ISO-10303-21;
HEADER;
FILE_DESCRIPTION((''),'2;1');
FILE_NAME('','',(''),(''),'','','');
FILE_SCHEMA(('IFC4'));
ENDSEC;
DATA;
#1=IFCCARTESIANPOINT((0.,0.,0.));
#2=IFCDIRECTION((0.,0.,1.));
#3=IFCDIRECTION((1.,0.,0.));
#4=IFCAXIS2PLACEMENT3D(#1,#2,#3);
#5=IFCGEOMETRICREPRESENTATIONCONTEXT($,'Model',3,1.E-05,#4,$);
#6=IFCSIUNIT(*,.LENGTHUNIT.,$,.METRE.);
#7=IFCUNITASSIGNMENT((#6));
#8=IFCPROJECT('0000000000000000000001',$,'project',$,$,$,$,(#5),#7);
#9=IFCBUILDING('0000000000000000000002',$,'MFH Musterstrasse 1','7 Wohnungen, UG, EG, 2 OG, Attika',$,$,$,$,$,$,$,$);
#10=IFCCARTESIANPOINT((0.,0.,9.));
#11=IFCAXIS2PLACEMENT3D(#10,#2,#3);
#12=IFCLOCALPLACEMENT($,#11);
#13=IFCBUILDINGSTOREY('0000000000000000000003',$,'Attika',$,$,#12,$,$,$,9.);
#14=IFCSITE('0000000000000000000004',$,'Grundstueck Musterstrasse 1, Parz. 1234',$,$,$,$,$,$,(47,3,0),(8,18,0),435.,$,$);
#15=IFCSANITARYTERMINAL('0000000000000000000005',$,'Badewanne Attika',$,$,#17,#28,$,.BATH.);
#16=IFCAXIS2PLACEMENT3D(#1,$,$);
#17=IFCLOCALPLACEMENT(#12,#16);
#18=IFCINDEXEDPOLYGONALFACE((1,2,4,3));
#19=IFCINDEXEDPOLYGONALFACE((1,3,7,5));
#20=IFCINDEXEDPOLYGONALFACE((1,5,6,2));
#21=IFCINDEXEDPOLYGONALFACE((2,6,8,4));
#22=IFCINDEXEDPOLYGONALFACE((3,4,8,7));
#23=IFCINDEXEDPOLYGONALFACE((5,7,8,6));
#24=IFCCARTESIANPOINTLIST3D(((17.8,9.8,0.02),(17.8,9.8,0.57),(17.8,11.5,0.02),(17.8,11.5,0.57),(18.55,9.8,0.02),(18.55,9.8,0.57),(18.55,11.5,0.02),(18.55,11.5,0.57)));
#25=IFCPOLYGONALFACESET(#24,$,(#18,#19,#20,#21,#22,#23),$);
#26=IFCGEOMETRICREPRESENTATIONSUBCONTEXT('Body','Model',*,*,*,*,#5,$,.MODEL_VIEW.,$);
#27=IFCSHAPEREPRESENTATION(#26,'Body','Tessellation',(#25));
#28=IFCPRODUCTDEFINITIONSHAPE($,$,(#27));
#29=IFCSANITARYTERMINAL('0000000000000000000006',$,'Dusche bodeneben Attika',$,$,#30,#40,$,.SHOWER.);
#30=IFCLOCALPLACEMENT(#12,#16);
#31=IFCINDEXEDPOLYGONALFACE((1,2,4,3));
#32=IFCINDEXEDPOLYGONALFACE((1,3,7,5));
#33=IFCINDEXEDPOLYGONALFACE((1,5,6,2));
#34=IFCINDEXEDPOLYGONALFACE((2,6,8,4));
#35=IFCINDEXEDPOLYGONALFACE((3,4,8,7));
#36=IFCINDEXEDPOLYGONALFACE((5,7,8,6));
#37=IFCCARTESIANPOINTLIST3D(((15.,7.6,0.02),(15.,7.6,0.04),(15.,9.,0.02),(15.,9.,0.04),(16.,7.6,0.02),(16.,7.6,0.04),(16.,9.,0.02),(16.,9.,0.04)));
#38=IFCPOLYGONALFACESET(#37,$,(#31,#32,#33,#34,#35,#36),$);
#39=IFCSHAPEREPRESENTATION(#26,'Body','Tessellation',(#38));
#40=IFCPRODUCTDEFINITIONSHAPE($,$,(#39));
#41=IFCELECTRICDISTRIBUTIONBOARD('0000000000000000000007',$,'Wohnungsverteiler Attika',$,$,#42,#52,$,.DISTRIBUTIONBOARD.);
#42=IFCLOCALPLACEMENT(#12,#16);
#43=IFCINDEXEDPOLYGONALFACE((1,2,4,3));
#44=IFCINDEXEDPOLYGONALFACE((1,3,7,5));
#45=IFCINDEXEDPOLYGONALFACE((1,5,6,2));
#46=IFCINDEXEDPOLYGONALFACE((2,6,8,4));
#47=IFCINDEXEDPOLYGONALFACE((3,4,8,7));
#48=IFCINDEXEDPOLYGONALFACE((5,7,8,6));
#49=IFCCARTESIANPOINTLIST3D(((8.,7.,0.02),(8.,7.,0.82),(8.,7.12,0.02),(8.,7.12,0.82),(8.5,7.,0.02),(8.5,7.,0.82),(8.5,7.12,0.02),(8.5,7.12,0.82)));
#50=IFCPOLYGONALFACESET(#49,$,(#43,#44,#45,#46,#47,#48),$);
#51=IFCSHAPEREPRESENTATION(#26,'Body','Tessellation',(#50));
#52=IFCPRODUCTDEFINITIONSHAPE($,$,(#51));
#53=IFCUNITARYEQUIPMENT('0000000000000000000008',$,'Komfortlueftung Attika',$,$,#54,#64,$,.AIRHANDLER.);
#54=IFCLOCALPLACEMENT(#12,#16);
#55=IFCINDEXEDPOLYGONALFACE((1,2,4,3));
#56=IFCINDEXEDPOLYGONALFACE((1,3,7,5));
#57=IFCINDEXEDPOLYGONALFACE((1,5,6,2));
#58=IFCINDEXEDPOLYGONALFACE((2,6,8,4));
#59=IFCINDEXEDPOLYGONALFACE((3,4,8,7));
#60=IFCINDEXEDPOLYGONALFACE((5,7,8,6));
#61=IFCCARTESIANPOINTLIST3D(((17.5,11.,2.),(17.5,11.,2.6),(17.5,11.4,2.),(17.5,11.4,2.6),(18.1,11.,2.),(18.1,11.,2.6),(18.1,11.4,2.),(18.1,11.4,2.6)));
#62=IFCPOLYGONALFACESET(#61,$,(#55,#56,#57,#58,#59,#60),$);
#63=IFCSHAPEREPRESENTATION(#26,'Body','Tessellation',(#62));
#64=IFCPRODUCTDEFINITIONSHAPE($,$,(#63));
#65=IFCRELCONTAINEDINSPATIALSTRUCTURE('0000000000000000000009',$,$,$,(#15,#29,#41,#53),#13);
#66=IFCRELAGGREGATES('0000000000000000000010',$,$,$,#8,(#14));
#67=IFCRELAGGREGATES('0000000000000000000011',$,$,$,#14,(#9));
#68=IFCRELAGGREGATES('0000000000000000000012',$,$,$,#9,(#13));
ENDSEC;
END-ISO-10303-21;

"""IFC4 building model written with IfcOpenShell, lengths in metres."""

from ifc_helpers import new_model, si_unit, frame, frame_2d, origin_with_axes, place, context, subcontext, project, spatial, rectangle, extrude, element, save


model = new_model("IFC4")

# Units and contexts
model_context = context("Model", 3, precision=1e-05, world=origin_with_axes())
body_context = subcontext(model_context, "Body", "Model", "MODEL_VIEW")
ifc_project = project(units=[si_unit("LENGTHUNIT", "METRE")], contexts=[model_context])

# Site, building, storey
site = spatial("IfcSite", under=ifc_project, Name="Grundstueck Musterstrasse 1, Parz. 1234", RefLatitude=(47, 3, 0), RefLongitude=(8, 18, 0), RefElevation=435.0)
building = spatial("IfcBuilding", under=site, Name="MFH Musterstrasse 1", Description="7 Wohnungen, UG, EG, 2 OG, Attika")
storey_placement = place(None, frame((0.0, 0.0, 9.0), z_axis=(0.0, 0.0, 1.0), x_axis=(1.0, 0.0, 0.0)))
storey = spatial("IfcBuildingStorey", under=building, at=storey_placement, Name="Attika", Elevation=9.0)

# Sanitary terminals
sanitary_terminal_1_placement = place(storey_placement, frame((17.8, 9.8, 0.02), z_axis=(0.0, 0.0, 1.0), x_axis=(1.0, 0.0, 0.0)))
element("IfcSanitaryTerminal", 1, at=sanitary_terminal_1_placement, inside=storey, Name="Badewanne Attika", PredefinedType="BATH", context=body_context, shape_type="SweptSolid", body=[
    extrude(rectangle(XDim=0.75, YDim=1.7, at=frame_2d((0.375, 0.85))), origin_with_axes(), (0.0, 0.0, 1.0), 0.55),
])
sanitary_terminal_2_placement = place(storey_placement, frame((15.0, 7.6, 0.02), z_axis=(0.0, 0.0, 1.0), x_axis=(1.0, 0.0, 0.0)))
element("IfcSanitaryTerminal", 2, at=sanitary_terminal_2_placement, inside=storey, Name="Dusche bodeneben Attika", PredefinedType="SHOWER", context=body_context, shape_type="SweptSolid", body=[
    extrude(rectangle(XDim=1.0, YDim=1.4, at=frame_2d((0.5, 0.7))), origin_with_axes(), (0.0, 0.0, 1.0), 0.02),
])

# Electric distribution board
electric_distribution_board_placement = place(storey_placement, frame((8.0, 7.0, 0.02), z_axis=(0.0, 0.0, 1.0), x_axis=(1.0, 0.0, 0.0)))
element("IfcElectricDistributionBoard", 3, at=electric_distribution_board_placement, inside=storey, Name="Wohnungsverteiler Attika", PredefinedType="DISTRIBUTIONBOARD", context=body_context, shape_type="SweptSolid", body=[
    extrude(rectangle(XDim=0.5, YDim=0.12, at=frame_2d((0.25, 0.06))), origin_with_axes(), (0.0, 0.0, 1.0), 0.8),
])

# Unitary equipment
unitary_equipment_placement = place(storey_placement, frame((17.5, 11.0, 2.0), z_axis=(0.0, 0.0, 1.0), x_axis=(1.0, 0.0, 0.0)))
element("IfcUnitaryEquipment", 4, at=unitary_equipment_placement, inside=storey, Name="Komfortlueftung Attika", PredefinedType="AIRHANDLER", context=body_context, shape_type="SweptSolid", body=[
    extrude(rectangle(XDim=0.6, YDim=0.4, at=frame_2d((0.3, 0.2))), origin_with_axes(), (0.0, 0.0, 1.0), 0.6),
])

save(model, "model.ifc")
